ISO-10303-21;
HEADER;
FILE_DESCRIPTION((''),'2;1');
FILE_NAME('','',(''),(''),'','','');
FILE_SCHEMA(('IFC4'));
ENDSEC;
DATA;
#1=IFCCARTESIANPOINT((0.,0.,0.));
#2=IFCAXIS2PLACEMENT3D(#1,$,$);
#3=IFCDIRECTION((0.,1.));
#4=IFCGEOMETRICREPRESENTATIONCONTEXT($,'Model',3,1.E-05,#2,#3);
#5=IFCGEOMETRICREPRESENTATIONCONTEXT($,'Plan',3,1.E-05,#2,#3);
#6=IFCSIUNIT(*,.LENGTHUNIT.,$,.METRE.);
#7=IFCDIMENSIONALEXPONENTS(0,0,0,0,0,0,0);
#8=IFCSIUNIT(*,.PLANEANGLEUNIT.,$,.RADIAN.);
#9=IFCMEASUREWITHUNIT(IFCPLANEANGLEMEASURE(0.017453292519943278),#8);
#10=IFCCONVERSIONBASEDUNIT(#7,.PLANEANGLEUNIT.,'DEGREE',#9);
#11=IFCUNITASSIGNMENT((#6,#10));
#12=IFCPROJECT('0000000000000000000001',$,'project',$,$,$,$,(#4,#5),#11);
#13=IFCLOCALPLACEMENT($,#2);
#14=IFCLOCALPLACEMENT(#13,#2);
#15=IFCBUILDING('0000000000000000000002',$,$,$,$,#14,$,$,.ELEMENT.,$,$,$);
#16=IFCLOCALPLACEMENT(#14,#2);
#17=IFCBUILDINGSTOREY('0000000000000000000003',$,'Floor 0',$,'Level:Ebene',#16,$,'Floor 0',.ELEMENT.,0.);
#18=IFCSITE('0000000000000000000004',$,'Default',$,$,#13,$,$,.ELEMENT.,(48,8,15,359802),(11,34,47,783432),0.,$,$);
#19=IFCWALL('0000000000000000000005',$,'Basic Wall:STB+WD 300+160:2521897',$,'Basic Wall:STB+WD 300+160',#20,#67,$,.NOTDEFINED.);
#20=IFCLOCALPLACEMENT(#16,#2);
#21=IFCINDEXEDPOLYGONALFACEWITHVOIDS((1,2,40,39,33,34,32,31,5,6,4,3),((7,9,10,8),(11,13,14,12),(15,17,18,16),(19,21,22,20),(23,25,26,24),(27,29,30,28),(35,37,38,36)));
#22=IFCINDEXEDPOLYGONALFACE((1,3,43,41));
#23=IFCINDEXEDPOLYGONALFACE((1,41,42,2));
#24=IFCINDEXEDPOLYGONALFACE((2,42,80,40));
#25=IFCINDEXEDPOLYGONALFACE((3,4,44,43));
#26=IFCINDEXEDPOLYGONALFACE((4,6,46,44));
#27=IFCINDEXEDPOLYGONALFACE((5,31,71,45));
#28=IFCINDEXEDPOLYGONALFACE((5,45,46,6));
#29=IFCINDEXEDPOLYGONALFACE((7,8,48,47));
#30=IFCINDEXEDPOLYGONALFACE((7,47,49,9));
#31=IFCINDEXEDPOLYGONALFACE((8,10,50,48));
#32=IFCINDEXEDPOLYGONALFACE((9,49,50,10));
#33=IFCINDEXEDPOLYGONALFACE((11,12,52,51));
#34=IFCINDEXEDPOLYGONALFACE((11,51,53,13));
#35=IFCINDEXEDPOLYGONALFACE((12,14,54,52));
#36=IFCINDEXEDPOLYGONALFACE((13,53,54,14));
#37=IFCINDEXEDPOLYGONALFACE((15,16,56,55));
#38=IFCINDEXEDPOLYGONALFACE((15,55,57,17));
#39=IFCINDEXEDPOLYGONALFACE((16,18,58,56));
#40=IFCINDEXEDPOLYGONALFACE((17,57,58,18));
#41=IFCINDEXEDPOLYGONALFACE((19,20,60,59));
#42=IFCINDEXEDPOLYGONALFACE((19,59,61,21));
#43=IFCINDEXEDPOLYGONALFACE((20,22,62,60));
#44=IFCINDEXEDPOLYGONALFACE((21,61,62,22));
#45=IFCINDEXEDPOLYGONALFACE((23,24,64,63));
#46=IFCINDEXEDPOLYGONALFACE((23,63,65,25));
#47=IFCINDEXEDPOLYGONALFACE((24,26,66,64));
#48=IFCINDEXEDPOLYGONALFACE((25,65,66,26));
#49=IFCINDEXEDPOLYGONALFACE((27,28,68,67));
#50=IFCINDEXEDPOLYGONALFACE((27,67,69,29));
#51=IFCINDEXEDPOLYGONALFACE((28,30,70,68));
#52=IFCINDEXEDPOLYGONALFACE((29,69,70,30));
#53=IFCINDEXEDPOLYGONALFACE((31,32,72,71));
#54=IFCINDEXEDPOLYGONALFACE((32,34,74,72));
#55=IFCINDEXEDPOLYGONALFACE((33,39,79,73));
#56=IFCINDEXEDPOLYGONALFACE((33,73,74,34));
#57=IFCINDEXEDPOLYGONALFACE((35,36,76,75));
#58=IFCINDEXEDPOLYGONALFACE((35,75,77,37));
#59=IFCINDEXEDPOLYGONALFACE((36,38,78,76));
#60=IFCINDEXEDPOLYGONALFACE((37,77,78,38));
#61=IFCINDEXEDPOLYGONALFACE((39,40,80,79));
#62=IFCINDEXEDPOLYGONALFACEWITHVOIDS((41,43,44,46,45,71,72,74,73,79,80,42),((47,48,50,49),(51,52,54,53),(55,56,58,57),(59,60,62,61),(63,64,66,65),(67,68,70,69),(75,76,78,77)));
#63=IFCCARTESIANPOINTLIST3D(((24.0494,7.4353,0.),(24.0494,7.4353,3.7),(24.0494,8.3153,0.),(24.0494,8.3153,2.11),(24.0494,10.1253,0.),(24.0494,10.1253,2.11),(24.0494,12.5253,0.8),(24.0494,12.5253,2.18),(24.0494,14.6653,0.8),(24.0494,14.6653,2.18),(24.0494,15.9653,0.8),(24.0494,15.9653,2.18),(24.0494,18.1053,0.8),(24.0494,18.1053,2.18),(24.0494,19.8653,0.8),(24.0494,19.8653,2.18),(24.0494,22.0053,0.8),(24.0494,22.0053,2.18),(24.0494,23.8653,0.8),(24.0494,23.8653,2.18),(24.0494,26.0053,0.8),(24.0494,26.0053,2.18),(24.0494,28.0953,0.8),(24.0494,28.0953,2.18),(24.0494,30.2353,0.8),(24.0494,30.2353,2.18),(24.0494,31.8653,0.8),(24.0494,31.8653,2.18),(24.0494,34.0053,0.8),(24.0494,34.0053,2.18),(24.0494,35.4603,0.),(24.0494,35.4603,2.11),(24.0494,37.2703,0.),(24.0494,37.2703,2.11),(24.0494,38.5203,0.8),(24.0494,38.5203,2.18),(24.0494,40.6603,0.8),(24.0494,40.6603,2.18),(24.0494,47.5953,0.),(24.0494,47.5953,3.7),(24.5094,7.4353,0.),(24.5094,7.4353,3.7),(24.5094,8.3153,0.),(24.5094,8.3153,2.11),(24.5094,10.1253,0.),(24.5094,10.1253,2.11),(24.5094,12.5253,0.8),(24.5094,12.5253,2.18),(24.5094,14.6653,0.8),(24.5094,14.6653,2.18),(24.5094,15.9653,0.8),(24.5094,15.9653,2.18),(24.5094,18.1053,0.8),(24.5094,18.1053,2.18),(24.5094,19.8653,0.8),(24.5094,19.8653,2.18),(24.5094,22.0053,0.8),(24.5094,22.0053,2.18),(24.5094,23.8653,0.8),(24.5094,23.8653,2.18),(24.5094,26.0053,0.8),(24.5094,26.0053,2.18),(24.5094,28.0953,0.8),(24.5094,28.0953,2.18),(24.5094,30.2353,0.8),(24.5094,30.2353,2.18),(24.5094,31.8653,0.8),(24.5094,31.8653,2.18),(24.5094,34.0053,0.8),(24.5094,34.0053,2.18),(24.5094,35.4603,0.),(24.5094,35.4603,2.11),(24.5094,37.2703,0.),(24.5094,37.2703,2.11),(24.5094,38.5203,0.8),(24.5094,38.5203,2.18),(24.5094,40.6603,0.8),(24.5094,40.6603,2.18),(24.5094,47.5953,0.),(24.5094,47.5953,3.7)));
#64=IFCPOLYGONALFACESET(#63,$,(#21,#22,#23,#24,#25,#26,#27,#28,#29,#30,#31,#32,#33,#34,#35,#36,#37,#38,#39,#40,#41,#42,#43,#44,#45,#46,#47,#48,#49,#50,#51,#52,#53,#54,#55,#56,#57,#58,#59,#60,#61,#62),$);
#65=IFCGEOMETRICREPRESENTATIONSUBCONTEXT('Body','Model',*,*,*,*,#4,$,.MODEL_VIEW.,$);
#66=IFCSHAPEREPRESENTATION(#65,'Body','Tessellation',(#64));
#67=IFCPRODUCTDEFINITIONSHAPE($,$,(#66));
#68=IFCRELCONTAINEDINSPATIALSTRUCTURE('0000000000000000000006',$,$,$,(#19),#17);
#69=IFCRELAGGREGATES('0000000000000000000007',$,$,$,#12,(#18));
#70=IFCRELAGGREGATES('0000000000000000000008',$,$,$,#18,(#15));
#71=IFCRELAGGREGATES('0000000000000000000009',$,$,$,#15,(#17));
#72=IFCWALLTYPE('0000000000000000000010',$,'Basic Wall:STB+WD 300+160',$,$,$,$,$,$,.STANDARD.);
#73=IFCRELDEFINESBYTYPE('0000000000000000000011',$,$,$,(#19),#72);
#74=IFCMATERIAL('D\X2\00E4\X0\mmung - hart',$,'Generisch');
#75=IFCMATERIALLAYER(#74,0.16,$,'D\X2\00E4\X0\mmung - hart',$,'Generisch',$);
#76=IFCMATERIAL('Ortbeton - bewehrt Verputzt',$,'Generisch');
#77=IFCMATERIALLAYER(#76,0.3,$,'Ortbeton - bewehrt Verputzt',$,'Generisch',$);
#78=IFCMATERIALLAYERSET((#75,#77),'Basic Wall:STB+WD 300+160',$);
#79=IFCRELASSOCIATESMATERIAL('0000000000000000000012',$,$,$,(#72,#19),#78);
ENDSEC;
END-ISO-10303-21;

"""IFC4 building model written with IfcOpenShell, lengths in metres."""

from ifc_helpers import new_model, entity, si_unit, converted_unit, direction, frame, frame_2d, origin, place, context, subcontext, project, spatial, rectangle, extrude, material, layer, layer_set, layer_usage, type_object, element, save


model = new_model("IFC4")

# Units and contexts
model_context = context("Model", 3, precision=1e-05, world=origin(), true_north=direction((0.0, 1.0)))
plan_context = context("Plan", 3, precision=1e-05, world=origin(), true_north=direction((0.0, 1.0)))
body_context = subcontext(model_context, "Body", "Model", "MODEL_VIEW")
ifc_project = project(units=[si_unit("LENGTHUNIT", "METRE"), converted_unit("PLANEANGLEUNIT", "DEGREE", entity("IfcPlaneAngleMeasure", 0.017453292519943278), si_unit("PLANEANGLEUNIT", "RADIAN"), dimensions=[0, 0, 0, 0, 0, 0, 0])], contexts=[model_context, plan_context])

# Site, building, storey
site_placement = place(None, origin())
site = spatial("IfcSite", under=ifc_project, at=site_placement, Name="Default", CompositionType="ELEMENT", RefLatitude=(48, 8, 15, 359802), RefLongitude=(11, 34, 47, 783432), RefElevation=0.0)
building_placement = place(site_placement, origin())
building = spatial("IfcBuilding", under=site, at=building_placement, CompositionType="ELEMENT")
storey_placement = place(building_placement, origin())
storey = spatial("IfcBuildingStorey", under=building, at=storey_placement, Name="Floor 0", ObjectType="Level:Ebene", LongName="Floor 0", CompositionType="ELEMENT", Elevation=0.0)

# Shared definitions
ifc_material_1 = material(Name="Ortbeton - bewehrt Verputzt", Category="Generisch")

# Wall, openings
ifc_material_2 = material(Name="Dämmung - hart", Category="Generisch")
ifc_layer_1 = layer(ifc_material_2, 0.16, Name="Dämmung - hart", Category="Generisch")
ifc_layer_2 = layer(ifc_material_1, 0.3, Name="Ortbeton - bewehrt Verputzt", Category="Generisch")
ifc_layer_set_1 = layer_set([ifc_layer_1, ifc_layer_2], Name="Basic Wall:STB+WD 300+160")
ifc_layer_usage_1 = layer_usage(ifc_layer_set_1, "AXIS2", "POSITIVE", -0.23)
wall_type_1 = type_object("IfcWallType", Name="Basic Wall:STB+WD 300+160", PredefinedType="STANDARD", material=ifc_layer_set_1)
wall_1_placement = place(storey_placement, frame((24.2794, 47.5953, 0.0), z_axis=(0.0, 0.0, 1.0), x_axis=(0.0, -1.0, 0.0)))
wall_1 = element("IfcWall", 1, at=wall_1_placement, inside=storey, type_object=wall_type_1, material=ifc_layer_usage_1, Name="Basic Wall:STB+WD 300+160:2521897", ObjectType="Basic Wall:STB+WD 300+160", PredefinedType="NOTDEFINED", context=body_context, shape_type="SweptSolid", body=[
    extrude(rectangle(XDim=40.16, YDim=0.46, at=frame_2d((20.08, 0.0), x_axis=(-1.0, 0.0))), origin(), (0.0, 0.0, 1.0), 3.7),
])
opening_1_placement = place(wall_1_placement, frame((37.47, -0.23, 0.0)))
element("IfcOpeningElement", 2, at=opening_1_placement, cuts=wall_1, PredefinedType="OPENING", context=body_context, shape_type="SweptSolid", body=[
    extrude(rectangle(XDim=2.11, YDim=1.81, at=frame_2d((1.055, 0.905), x_axis=(1.0, 0.0))), frame((0.0, 0.0, 0.0), z_axis=(0.0, 1.0, 0.0), x_axis=(0.0, 0.0, 1.0)), (0.0, 0.0, 1.0), 0.46),
])
opening_2_placement = place(wall_1_placement, frame((10.325, -0.23, 0.0)))
element("IfcOpeningElement", 3, at=opening_2_placement, cuts=wall_1, PredefinedType="OPENING", context=body_context, shape_type="SweptSolid", body=[
    extrude(rectangle(XDim=2.11, YDim=1.81, at=frame_2d((1.055, 0.905), x_axis=(1.0, 0.0))), frame((0.0, 0.0, 0.0), z_axis=(0.0, 1.0, 0.0), x_axis=(0.0, 0.0, 1.0)), (0.0, 0.0, 1.0), 0.46),
])
opening_3_placement = place(wall_1_placement, frame((47.5953, -24.2794, 0.8), z_axis=(0.0, 0.0, 1.0), x_axis=(0.0, 1.0, 0.0)))
element("IfcOpeningElement", 4, at=opening_3_placement, cuts=wall_1, PredefinedType="OPENING", context=body_context, shape_type="SweptSolid", body=[
    extrude(rectangle(XDim=1.38, YDim=2.14, at=frame_2d((0.0, 0.0), x_axis=(0.0, 1.0))), frame((22.9854, 17.0353, 0.69), z_axis=(1.0, 0.0, 0.0), x_axis=(0.0, 1.0, 0.0)), (0.0, 0.0, 1.0), 3.048),
])
opening_4_placement = place(wall_1_placement, frame((47.5953, -24.2794, 0.8), z_axis=(0.0, 0.0, 1.0), x_axis=(0.0, 1.0, 0.0)))
element("IfcOpeningElement", 5, at=opening_4_placement, cuts=wall_1, PredefinedType="OPENING", context=body_context, shape_type="SweptSolid", body=[
    extrude(rectangle(XDim=1.38, YDim=2.14, at=frame_2d((0.0, 0.0), x_axis=(0.0, 1.0))), frame((22.9854, 20.9353, 0.69), z_axis=(1.0, 0.0, 0.0), x_axis=(0.0, 1.0, 0.0)), (0.0, 0.0, 1.0), 3.048),
])
opening_5_placement = place(wall_1_placement, frame((47.5953, -24.2794, 0.8), z_axis=(0.0, 0.0, 1.0), x_axis=(0.0, 1.0, 0.0)))
element("IfcOpeningElement", 6, at=opening_5_placement, cuts=wall_1, PredefinedType="OPENING", context=body_context, shape_type="SweptSolid", body=[
    extrude(rectangle(XDim=1.38, YDim=2.14, at=frame_2d((0.0, 0.0), x_axis=(0.0, 1.0))), frame((22.9854, 24.9353, 0.69), z_axis=(1.0, 0.0, 0.0), x_axis=(0.0, 1.0, 0.0)), (0.0, 0.0, 1.0), 3.048),
])
opening_6_placement = place(wall_1_placement, frame((47.5953, -24.2794, 0.8), z_axis=(0.0, 0.0, 1.0), x_axis=(0.0, 1.0, 0.0)))
element("IfcOpeningElement", 7, at=opening_6_placement, cuts=wall_1, PredefinedType="OPENING", context=body_context, shape_type="SweptSolid", body=[
    extrude(rectangle(XDim=1.38, YDim=2.14, at=frame_2d((0.0, 0.0), x_axis=(0.0, 1.0))), frame((22.9854, 29.1653, 0.69), z_axis=(1.0, 0.0, 0.0), x_axis=(0.0, 1.0, 0.0)), (0.0, 0.0, 1.0), 3.048),
])
opening_7_placement = place(wall_1_placement, frame((47.5953, -24.2794, 0.8), z_axis=(0.0, 0.0, 1.0), x_axis=(0.0, 1.0, 0.0)))
element("IfcOpeningElement", 8, at=opening_7_placement, cuts=wall_1, PredefinedType="OPENING", context=body_context, shape_type="SweptSolid", body=[
    extrude(rectangle(XDim=1.38, YDim=2.14, at=frame_2d((0.0, 0.0), x_axis=(0.0, 1.0))), frame((22.9854, 32.9353, 0.69), z_axis=(1.0, 0.0, 0.0), x_axis=(0.0, 1.0, 0.0)), (0.0, 0.0, 1.0), 3.048),
])
opening_8_placement = place(wall_1_placement, frame((47.5953, -24.2794, 0.8), z_axis=(0.0, 0.0, 1.0), x_axis=(0.0, 1.0, 0.0)))
element("IfcOpeningElement", 9, at=opening_8_placement, cuts=wall_1, PredefinedType="OPENING", context=body_context, shape_type="SweptSolid", body=[
    extrude(rectangle(XDim=1.38, YDim=2.14, at=frame_2d((0.0, 0.0), x_axis=(0.0, 1.0))), frame((22.9854, 39.5903, 0.69), z_axis=(1.0, 0.0, 0.0), x_axis=(0.0, 1.0, 0.0)), (0.0, 0.0, 1.0), 3.048),
])
opening_9_placement = place(wall_1_placement, frame((47.5953, -24.2794, 0.8), z_axis=(0.0, 0.0, 1.0), x_axis=(0.0, 1.0, 0.0)))
element("IfcOpeningElement", 10, at=opening_9_placement, cuts=wall_1, PredefinedType="OPENING", context=body_context, shape_type="SweptSolid", body=[
    extrude(rectangle(XDim=1.38, YDim=2.14, at=frame_2d((0.0, 0.0), x_axis=(0.0, 1.0))), frame((22.9854, 13.5953, 0.69), z_axis=(1.0, 0.0, 0.0), x_axis=(0.0, 1.0, 0.0)), (0.0, 0.0, 1.0), 3.048),
])

save(model, "model.ifc")
